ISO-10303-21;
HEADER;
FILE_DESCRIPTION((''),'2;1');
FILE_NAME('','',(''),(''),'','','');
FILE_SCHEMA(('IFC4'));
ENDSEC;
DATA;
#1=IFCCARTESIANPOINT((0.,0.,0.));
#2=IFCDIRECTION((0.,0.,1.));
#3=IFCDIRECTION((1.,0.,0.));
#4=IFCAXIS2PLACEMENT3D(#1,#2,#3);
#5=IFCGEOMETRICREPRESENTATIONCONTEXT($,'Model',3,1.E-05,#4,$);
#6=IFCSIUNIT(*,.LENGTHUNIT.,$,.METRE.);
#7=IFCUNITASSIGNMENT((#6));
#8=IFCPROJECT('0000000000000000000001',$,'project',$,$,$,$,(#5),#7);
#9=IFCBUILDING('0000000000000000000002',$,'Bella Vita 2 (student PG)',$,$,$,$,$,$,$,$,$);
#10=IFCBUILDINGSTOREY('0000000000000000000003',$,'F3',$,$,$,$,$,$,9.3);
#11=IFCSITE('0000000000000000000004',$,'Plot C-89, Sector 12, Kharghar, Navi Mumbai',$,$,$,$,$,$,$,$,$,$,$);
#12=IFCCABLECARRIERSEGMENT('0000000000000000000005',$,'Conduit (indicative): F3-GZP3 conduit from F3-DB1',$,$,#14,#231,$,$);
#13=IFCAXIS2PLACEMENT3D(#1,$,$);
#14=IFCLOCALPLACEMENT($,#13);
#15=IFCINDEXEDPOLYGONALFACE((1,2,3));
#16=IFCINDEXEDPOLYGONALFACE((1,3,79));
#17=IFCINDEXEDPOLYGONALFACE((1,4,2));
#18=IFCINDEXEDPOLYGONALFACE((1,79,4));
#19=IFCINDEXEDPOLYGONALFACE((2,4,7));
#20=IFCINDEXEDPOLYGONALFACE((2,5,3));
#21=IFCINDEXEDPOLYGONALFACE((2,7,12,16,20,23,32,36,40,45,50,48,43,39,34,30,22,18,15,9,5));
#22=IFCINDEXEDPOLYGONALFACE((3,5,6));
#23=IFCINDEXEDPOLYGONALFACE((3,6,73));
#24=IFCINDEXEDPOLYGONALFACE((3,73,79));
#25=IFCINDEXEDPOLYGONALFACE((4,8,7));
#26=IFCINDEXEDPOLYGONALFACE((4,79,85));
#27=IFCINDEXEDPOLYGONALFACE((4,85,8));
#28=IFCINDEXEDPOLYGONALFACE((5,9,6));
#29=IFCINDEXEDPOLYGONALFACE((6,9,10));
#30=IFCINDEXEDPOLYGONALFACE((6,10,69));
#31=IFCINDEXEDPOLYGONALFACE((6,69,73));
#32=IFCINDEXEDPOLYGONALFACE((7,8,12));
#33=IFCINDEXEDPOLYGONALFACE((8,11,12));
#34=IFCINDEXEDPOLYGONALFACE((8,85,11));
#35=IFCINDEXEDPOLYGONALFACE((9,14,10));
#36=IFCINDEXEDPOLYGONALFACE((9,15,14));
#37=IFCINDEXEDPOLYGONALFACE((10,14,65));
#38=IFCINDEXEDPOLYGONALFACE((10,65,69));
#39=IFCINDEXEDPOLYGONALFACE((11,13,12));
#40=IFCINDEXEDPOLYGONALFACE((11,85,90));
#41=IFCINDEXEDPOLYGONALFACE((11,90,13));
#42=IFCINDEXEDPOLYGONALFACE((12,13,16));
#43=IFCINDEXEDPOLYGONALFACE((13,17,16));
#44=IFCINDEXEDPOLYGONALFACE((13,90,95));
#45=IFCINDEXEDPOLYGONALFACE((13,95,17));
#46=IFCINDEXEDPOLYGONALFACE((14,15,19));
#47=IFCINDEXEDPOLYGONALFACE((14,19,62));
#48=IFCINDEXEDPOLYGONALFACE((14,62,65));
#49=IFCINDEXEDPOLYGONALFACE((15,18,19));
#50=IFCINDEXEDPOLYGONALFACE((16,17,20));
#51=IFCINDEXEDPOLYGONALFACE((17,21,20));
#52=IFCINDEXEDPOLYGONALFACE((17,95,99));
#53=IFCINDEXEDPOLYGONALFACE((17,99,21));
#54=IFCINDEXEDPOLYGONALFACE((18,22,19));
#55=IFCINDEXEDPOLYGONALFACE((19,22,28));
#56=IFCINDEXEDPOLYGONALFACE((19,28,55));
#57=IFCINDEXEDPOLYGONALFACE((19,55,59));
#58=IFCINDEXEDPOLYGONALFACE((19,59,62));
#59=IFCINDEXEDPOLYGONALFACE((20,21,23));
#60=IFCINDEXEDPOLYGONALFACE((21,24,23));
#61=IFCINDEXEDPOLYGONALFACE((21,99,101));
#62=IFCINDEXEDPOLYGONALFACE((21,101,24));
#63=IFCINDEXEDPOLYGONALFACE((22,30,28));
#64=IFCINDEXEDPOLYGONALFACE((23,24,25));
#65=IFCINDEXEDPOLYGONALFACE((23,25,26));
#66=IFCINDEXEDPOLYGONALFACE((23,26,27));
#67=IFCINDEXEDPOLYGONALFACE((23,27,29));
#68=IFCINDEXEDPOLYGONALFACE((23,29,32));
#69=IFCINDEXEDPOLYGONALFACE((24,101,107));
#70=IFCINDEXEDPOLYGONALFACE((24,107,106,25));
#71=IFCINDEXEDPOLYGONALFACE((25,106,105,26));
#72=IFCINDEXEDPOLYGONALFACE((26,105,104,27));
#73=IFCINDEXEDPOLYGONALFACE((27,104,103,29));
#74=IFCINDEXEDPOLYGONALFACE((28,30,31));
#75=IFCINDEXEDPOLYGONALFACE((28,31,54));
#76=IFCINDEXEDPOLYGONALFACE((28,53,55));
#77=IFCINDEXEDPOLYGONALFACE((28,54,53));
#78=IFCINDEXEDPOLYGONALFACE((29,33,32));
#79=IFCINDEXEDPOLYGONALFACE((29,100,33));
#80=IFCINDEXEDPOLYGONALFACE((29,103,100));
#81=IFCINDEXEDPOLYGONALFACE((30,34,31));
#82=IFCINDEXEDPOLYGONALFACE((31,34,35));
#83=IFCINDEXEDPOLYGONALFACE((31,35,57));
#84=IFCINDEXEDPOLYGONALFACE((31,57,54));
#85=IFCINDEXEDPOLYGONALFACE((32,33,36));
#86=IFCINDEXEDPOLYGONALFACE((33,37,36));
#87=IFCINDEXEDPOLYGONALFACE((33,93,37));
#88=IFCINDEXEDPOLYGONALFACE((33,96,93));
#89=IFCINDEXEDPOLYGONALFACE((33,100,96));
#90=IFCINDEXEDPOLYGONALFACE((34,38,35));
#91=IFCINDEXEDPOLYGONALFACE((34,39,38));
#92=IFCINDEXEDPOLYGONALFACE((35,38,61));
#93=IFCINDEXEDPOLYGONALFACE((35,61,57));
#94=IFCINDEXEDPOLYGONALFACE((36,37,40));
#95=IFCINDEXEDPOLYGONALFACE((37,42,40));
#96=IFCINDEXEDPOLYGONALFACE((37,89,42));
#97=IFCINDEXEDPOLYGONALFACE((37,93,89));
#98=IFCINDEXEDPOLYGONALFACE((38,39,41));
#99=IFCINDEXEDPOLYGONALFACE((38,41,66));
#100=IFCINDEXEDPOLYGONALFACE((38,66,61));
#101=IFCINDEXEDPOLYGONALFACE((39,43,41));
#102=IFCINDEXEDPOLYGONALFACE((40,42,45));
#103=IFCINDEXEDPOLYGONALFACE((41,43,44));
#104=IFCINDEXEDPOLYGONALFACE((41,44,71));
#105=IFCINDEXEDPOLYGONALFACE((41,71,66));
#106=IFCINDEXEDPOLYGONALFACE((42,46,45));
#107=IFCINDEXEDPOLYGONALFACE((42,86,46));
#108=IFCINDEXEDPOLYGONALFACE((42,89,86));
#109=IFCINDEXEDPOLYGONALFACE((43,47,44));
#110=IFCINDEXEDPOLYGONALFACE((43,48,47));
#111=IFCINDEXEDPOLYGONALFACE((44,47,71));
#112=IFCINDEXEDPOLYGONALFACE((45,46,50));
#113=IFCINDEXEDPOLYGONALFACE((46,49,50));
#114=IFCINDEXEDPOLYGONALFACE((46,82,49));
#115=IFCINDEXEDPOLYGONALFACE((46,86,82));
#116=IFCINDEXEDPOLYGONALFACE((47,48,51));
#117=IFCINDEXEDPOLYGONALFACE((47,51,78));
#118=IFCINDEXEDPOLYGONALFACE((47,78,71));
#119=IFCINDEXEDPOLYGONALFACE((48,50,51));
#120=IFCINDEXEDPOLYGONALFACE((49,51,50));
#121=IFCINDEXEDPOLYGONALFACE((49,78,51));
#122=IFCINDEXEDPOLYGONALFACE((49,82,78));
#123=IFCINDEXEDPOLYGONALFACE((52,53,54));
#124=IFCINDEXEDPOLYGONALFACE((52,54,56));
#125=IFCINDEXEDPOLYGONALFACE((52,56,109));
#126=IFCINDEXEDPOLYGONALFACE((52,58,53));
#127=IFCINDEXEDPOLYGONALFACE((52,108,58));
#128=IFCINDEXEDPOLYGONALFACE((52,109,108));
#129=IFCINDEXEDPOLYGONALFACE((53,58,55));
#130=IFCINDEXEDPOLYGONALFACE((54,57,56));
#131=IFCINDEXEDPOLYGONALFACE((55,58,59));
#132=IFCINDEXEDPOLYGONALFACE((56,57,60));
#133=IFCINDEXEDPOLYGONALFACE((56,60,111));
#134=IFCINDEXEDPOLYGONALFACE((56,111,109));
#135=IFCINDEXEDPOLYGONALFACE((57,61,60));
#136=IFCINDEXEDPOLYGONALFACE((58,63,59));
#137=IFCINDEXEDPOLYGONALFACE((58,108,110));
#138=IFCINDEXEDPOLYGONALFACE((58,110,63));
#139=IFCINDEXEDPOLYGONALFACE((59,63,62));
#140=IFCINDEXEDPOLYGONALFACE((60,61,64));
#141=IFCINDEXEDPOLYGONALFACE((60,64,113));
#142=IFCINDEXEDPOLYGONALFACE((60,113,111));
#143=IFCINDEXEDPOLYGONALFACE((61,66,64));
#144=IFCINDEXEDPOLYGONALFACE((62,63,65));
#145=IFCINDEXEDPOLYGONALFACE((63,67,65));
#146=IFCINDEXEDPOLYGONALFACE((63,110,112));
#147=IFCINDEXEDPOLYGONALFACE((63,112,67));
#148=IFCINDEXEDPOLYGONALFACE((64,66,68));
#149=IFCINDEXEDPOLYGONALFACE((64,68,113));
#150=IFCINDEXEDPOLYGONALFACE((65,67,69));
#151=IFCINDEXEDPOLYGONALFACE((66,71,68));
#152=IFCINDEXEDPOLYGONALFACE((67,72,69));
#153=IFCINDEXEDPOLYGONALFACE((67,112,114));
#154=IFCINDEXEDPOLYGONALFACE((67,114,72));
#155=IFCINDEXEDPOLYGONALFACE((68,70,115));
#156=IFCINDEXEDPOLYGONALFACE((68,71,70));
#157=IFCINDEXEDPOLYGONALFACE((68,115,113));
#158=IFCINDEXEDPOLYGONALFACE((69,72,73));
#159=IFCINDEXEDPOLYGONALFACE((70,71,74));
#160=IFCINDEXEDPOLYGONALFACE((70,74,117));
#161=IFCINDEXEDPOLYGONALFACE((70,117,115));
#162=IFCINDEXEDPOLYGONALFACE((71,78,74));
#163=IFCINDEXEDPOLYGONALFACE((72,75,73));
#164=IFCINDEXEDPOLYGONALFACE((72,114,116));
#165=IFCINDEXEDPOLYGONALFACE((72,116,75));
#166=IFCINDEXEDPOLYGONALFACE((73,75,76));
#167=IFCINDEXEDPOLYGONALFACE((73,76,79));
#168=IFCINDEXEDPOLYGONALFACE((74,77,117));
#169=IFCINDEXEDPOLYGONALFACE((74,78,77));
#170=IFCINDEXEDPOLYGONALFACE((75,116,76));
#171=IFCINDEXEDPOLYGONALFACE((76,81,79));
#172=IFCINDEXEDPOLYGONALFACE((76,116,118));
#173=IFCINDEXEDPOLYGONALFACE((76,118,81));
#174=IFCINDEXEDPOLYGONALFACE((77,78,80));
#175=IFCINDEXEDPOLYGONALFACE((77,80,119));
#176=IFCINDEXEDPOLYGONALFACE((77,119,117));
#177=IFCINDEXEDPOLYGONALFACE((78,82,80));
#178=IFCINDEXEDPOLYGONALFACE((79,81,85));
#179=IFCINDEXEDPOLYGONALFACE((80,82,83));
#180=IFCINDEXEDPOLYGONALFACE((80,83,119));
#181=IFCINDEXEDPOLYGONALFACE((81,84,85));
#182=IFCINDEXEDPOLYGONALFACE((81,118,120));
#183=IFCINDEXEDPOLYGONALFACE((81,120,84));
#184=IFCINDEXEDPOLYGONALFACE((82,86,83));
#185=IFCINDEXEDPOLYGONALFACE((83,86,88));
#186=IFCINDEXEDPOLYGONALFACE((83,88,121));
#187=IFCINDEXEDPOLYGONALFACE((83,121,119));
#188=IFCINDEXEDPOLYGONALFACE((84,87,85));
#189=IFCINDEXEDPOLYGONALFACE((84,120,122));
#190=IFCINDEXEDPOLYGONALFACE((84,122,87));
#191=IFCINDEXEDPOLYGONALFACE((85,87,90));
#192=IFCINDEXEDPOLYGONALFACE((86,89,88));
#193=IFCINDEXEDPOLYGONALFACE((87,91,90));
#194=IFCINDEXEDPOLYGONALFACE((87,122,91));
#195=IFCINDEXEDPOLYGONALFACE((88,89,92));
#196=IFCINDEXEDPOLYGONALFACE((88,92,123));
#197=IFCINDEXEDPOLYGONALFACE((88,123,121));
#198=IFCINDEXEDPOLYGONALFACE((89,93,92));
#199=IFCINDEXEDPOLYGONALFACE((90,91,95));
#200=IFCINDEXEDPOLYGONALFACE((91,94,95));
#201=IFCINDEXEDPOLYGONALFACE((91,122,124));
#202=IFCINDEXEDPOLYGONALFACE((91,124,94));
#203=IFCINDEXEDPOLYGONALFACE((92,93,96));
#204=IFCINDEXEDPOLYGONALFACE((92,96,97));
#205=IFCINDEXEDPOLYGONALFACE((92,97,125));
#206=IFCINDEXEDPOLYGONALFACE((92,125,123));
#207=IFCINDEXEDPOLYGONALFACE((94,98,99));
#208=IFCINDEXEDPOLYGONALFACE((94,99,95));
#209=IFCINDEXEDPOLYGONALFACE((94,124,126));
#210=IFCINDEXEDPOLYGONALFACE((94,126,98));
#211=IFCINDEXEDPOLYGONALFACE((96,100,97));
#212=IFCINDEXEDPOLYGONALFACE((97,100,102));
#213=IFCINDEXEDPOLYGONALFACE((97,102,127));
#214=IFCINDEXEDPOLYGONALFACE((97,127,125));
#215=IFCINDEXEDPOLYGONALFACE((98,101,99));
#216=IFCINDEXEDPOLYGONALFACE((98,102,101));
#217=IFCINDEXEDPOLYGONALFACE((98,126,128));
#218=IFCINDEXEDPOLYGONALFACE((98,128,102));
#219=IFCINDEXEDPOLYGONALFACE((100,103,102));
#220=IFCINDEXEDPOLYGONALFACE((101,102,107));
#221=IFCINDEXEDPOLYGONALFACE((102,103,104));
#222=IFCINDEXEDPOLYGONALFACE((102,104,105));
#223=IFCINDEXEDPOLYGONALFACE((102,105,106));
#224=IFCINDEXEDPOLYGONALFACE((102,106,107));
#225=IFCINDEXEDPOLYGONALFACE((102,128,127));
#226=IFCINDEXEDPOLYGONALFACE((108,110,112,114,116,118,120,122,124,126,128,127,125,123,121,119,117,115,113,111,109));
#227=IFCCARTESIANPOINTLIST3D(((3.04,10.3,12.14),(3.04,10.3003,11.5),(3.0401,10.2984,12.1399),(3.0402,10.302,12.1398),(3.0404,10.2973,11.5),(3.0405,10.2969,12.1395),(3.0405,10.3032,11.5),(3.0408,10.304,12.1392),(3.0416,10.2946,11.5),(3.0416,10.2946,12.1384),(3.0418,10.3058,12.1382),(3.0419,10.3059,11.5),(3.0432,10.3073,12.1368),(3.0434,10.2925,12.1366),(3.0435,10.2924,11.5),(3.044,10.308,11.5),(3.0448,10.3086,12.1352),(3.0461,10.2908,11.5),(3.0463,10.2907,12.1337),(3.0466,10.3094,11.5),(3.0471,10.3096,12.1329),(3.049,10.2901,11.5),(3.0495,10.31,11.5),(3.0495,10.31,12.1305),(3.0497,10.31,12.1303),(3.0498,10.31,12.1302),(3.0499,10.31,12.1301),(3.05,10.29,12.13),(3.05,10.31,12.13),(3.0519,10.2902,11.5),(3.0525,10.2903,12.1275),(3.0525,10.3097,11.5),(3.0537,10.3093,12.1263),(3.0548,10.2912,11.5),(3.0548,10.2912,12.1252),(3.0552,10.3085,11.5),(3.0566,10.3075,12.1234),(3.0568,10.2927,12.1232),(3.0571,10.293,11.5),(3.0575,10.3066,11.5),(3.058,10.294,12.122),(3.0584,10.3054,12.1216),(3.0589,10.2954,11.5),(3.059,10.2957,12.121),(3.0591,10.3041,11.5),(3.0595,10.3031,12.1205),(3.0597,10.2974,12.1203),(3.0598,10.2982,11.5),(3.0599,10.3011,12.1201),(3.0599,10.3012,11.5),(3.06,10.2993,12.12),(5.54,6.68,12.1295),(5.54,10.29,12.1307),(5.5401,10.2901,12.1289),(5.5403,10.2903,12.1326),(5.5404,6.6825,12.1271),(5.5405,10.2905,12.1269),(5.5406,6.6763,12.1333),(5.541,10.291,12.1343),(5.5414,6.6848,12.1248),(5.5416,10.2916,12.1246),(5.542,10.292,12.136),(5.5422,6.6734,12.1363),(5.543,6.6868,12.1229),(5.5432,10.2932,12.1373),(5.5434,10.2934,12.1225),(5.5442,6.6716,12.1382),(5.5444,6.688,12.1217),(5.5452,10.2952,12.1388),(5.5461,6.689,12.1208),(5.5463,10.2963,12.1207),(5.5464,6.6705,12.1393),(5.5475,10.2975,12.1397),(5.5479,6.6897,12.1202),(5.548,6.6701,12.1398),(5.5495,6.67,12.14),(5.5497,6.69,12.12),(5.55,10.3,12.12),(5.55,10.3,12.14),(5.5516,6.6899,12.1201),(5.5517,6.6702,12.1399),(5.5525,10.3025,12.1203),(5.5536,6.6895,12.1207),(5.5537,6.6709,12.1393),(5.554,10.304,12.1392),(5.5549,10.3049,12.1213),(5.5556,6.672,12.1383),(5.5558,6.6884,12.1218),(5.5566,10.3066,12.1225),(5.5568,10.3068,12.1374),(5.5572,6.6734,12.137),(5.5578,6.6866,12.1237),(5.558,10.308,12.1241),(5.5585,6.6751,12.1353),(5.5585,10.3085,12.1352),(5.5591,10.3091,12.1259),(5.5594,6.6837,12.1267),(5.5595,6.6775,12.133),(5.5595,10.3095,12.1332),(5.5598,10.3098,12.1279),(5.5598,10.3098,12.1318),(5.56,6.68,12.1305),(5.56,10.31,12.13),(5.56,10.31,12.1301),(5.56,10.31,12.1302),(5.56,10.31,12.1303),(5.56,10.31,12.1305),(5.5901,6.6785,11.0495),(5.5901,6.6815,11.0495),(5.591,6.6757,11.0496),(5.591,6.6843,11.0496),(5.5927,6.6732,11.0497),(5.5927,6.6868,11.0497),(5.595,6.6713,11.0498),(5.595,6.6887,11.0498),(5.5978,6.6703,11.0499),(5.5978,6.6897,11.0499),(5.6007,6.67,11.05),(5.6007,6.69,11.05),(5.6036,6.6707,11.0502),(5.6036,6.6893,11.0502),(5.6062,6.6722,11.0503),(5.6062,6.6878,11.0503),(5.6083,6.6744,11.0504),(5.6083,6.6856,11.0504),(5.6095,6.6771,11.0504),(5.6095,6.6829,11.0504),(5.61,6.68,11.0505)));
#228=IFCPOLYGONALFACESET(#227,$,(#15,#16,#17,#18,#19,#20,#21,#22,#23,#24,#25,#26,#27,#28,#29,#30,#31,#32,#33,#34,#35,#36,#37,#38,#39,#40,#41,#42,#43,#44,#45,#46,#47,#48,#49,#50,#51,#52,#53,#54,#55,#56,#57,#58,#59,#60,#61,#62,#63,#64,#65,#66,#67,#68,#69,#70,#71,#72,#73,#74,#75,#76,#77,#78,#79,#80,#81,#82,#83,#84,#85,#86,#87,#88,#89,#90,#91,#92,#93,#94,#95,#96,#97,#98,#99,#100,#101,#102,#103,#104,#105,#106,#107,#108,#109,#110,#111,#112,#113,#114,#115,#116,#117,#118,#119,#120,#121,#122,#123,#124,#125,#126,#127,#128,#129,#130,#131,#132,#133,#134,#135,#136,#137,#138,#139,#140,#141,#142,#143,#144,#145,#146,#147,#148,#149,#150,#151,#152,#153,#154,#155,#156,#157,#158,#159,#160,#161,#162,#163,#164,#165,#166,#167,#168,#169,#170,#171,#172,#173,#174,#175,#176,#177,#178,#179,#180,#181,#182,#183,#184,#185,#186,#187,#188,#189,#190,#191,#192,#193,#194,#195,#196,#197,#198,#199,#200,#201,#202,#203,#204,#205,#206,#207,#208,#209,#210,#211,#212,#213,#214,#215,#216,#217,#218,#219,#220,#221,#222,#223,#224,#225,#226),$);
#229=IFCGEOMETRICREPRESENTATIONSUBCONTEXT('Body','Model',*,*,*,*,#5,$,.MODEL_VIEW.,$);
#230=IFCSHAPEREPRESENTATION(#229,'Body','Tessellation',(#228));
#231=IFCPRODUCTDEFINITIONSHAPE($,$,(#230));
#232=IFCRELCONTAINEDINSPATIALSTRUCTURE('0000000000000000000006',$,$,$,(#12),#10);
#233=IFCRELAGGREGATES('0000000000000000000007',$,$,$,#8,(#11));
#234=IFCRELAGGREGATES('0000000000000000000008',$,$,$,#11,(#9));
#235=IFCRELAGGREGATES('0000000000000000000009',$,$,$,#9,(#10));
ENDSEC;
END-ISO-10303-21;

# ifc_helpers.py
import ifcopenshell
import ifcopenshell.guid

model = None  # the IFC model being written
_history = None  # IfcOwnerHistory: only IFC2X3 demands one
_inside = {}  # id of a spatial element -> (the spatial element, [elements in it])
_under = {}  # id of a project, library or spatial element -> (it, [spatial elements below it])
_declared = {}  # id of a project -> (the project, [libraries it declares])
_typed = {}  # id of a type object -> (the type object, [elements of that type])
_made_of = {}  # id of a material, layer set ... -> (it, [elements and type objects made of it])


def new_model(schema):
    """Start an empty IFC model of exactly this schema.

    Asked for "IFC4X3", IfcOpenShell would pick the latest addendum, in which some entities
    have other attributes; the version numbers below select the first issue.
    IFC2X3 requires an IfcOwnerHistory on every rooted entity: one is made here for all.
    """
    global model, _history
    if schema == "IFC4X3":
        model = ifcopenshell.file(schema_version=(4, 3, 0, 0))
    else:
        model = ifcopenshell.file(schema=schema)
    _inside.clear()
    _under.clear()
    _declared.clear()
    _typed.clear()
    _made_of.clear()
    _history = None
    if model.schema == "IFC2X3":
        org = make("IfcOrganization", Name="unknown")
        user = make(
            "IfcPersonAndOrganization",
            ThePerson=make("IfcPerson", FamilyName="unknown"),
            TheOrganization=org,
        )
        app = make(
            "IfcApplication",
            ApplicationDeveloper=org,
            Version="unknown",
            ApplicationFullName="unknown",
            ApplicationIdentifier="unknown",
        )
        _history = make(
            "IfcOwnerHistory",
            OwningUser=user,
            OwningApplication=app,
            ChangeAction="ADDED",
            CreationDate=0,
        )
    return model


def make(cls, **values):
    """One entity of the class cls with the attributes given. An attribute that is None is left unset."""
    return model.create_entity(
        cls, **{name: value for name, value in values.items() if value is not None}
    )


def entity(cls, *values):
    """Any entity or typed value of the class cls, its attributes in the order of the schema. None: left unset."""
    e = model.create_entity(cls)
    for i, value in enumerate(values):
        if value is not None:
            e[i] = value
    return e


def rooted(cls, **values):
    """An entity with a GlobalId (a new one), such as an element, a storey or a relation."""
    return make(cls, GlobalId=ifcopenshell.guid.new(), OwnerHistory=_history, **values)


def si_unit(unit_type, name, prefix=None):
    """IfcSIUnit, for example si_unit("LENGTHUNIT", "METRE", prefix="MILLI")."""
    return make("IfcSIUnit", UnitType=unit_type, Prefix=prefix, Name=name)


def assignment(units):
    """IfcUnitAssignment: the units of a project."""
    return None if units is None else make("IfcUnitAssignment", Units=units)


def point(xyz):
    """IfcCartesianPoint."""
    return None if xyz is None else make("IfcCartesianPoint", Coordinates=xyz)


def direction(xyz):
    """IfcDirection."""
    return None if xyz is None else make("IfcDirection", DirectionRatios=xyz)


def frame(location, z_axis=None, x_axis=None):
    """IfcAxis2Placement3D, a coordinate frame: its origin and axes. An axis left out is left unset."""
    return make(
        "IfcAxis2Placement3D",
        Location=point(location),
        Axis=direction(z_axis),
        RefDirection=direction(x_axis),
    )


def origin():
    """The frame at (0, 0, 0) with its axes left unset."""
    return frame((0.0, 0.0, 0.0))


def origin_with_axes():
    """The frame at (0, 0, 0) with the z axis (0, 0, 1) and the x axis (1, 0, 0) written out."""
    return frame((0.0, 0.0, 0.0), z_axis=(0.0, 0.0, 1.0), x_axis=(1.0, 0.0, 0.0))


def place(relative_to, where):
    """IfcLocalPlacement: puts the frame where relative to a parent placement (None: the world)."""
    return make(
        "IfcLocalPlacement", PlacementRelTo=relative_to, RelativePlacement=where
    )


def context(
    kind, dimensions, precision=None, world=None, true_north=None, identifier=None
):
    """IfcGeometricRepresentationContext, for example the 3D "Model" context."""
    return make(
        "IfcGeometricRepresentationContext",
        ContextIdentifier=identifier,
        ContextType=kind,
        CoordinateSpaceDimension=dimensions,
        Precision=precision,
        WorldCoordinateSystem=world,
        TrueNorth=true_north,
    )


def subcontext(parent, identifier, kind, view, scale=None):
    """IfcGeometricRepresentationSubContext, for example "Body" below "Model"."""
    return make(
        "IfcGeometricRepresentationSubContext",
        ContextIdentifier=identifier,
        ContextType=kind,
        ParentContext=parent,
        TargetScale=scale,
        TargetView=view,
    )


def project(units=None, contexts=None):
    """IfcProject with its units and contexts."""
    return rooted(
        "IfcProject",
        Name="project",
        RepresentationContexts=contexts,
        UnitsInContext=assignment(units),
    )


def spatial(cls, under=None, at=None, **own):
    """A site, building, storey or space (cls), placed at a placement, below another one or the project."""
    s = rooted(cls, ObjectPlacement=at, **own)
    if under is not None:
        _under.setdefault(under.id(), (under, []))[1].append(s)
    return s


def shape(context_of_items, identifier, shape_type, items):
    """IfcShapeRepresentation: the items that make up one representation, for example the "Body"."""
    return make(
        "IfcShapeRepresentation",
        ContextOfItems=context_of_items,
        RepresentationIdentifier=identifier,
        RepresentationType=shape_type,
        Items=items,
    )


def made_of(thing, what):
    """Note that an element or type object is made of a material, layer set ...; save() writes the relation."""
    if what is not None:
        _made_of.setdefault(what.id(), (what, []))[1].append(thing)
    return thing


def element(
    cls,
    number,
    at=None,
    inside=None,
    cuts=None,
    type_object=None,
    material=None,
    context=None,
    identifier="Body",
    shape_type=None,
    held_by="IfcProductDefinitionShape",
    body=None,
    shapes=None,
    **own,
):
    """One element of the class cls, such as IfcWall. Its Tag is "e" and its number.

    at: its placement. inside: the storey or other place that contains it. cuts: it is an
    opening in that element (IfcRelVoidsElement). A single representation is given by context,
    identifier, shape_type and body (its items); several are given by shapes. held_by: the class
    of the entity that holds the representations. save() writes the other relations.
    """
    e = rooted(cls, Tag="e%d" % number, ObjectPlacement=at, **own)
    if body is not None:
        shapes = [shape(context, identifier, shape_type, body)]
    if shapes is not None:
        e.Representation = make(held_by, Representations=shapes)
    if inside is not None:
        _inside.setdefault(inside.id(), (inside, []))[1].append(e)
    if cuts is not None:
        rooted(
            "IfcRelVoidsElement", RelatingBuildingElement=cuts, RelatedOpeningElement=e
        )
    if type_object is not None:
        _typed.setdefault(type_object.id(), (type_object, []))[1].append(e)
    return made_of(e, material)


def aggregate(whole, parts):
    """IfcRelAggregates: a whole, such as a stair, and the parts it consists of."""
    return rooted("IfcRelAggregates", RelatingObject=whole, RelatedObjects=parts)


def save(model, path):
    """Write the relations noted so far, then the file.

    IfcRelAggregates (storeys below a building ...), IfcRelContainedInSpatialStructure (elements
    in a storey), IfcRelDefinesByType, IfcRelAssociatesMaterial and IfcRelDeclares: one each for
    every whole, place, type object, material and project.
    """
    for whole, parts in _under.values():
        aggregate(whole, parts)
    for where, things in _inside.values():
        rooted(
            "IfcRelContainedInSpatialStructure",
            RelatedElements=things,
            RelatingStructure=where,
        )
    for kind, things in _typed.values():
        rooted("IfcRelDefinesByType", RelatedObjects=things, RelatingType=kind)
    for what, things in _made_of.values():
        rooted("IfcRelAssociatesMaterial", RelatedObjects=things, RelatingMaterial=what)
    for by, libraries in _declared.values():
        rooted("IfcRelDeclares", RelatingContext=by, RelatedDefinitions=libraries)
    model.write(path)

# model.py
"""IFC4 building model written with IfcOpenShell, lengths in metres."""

from ifc_helpers import new_model, entity, si_unit, origin, origin_with_axes, place, context, subcontext, project, spatial, element, save


model = new_model("IFC4")

# Units and contexts
model_context = context("Model", 3, precision=1e-05, world=origin_with_axes())
body_context = subcontext(model_context, "Body", "Model", "MODEL_VIEW")
ifc_project = project(units=[si_unit("LENGTHUNIT", "METRE")], contexts=[model_context])

# Site, building, storey
site = spatial("IfcSite", under=ifc_project, Name="Plot C-89, Sector 12, Kharghar, Navi Mumbai")
building = spatial("IfcBuilding", under=site, Name="Bella Vita 2 (student PG)")
storey = spatial("IfcBuildingStorey", under=building, Name="F3", Elevation=9.3)

# Cable carrier segment
cable_carrier_segment_1_placement = place(None, origin())
element("IfcCableCarrierSegment", 1, at=cable_carrier_segment_1_placement, inside=storey, Name="Conduit (indicative): F3-GZP3 conduit from F3-DB1", context=body_context, shape_type="AdvancedSweptSolid", body=[
    entity("IfcSweptDiskSolid", entity("IfcPolyline", [entity("IfcCartesianPoint", [5.6, 6.68, 11.05]), entity("IfcCartesianPoint", [5.55, 6.68, 12.13]), entity("IfcCartesianPoint", [5.55, 10.3, 12.13]), entity("IfcCartesianPoint", [3.05, 10.3, 12.13]), entity("IfcCartesianPoint", [3.05, 10.3, 11.5])]), 0.01),
])

save(model, "model.ifc")
